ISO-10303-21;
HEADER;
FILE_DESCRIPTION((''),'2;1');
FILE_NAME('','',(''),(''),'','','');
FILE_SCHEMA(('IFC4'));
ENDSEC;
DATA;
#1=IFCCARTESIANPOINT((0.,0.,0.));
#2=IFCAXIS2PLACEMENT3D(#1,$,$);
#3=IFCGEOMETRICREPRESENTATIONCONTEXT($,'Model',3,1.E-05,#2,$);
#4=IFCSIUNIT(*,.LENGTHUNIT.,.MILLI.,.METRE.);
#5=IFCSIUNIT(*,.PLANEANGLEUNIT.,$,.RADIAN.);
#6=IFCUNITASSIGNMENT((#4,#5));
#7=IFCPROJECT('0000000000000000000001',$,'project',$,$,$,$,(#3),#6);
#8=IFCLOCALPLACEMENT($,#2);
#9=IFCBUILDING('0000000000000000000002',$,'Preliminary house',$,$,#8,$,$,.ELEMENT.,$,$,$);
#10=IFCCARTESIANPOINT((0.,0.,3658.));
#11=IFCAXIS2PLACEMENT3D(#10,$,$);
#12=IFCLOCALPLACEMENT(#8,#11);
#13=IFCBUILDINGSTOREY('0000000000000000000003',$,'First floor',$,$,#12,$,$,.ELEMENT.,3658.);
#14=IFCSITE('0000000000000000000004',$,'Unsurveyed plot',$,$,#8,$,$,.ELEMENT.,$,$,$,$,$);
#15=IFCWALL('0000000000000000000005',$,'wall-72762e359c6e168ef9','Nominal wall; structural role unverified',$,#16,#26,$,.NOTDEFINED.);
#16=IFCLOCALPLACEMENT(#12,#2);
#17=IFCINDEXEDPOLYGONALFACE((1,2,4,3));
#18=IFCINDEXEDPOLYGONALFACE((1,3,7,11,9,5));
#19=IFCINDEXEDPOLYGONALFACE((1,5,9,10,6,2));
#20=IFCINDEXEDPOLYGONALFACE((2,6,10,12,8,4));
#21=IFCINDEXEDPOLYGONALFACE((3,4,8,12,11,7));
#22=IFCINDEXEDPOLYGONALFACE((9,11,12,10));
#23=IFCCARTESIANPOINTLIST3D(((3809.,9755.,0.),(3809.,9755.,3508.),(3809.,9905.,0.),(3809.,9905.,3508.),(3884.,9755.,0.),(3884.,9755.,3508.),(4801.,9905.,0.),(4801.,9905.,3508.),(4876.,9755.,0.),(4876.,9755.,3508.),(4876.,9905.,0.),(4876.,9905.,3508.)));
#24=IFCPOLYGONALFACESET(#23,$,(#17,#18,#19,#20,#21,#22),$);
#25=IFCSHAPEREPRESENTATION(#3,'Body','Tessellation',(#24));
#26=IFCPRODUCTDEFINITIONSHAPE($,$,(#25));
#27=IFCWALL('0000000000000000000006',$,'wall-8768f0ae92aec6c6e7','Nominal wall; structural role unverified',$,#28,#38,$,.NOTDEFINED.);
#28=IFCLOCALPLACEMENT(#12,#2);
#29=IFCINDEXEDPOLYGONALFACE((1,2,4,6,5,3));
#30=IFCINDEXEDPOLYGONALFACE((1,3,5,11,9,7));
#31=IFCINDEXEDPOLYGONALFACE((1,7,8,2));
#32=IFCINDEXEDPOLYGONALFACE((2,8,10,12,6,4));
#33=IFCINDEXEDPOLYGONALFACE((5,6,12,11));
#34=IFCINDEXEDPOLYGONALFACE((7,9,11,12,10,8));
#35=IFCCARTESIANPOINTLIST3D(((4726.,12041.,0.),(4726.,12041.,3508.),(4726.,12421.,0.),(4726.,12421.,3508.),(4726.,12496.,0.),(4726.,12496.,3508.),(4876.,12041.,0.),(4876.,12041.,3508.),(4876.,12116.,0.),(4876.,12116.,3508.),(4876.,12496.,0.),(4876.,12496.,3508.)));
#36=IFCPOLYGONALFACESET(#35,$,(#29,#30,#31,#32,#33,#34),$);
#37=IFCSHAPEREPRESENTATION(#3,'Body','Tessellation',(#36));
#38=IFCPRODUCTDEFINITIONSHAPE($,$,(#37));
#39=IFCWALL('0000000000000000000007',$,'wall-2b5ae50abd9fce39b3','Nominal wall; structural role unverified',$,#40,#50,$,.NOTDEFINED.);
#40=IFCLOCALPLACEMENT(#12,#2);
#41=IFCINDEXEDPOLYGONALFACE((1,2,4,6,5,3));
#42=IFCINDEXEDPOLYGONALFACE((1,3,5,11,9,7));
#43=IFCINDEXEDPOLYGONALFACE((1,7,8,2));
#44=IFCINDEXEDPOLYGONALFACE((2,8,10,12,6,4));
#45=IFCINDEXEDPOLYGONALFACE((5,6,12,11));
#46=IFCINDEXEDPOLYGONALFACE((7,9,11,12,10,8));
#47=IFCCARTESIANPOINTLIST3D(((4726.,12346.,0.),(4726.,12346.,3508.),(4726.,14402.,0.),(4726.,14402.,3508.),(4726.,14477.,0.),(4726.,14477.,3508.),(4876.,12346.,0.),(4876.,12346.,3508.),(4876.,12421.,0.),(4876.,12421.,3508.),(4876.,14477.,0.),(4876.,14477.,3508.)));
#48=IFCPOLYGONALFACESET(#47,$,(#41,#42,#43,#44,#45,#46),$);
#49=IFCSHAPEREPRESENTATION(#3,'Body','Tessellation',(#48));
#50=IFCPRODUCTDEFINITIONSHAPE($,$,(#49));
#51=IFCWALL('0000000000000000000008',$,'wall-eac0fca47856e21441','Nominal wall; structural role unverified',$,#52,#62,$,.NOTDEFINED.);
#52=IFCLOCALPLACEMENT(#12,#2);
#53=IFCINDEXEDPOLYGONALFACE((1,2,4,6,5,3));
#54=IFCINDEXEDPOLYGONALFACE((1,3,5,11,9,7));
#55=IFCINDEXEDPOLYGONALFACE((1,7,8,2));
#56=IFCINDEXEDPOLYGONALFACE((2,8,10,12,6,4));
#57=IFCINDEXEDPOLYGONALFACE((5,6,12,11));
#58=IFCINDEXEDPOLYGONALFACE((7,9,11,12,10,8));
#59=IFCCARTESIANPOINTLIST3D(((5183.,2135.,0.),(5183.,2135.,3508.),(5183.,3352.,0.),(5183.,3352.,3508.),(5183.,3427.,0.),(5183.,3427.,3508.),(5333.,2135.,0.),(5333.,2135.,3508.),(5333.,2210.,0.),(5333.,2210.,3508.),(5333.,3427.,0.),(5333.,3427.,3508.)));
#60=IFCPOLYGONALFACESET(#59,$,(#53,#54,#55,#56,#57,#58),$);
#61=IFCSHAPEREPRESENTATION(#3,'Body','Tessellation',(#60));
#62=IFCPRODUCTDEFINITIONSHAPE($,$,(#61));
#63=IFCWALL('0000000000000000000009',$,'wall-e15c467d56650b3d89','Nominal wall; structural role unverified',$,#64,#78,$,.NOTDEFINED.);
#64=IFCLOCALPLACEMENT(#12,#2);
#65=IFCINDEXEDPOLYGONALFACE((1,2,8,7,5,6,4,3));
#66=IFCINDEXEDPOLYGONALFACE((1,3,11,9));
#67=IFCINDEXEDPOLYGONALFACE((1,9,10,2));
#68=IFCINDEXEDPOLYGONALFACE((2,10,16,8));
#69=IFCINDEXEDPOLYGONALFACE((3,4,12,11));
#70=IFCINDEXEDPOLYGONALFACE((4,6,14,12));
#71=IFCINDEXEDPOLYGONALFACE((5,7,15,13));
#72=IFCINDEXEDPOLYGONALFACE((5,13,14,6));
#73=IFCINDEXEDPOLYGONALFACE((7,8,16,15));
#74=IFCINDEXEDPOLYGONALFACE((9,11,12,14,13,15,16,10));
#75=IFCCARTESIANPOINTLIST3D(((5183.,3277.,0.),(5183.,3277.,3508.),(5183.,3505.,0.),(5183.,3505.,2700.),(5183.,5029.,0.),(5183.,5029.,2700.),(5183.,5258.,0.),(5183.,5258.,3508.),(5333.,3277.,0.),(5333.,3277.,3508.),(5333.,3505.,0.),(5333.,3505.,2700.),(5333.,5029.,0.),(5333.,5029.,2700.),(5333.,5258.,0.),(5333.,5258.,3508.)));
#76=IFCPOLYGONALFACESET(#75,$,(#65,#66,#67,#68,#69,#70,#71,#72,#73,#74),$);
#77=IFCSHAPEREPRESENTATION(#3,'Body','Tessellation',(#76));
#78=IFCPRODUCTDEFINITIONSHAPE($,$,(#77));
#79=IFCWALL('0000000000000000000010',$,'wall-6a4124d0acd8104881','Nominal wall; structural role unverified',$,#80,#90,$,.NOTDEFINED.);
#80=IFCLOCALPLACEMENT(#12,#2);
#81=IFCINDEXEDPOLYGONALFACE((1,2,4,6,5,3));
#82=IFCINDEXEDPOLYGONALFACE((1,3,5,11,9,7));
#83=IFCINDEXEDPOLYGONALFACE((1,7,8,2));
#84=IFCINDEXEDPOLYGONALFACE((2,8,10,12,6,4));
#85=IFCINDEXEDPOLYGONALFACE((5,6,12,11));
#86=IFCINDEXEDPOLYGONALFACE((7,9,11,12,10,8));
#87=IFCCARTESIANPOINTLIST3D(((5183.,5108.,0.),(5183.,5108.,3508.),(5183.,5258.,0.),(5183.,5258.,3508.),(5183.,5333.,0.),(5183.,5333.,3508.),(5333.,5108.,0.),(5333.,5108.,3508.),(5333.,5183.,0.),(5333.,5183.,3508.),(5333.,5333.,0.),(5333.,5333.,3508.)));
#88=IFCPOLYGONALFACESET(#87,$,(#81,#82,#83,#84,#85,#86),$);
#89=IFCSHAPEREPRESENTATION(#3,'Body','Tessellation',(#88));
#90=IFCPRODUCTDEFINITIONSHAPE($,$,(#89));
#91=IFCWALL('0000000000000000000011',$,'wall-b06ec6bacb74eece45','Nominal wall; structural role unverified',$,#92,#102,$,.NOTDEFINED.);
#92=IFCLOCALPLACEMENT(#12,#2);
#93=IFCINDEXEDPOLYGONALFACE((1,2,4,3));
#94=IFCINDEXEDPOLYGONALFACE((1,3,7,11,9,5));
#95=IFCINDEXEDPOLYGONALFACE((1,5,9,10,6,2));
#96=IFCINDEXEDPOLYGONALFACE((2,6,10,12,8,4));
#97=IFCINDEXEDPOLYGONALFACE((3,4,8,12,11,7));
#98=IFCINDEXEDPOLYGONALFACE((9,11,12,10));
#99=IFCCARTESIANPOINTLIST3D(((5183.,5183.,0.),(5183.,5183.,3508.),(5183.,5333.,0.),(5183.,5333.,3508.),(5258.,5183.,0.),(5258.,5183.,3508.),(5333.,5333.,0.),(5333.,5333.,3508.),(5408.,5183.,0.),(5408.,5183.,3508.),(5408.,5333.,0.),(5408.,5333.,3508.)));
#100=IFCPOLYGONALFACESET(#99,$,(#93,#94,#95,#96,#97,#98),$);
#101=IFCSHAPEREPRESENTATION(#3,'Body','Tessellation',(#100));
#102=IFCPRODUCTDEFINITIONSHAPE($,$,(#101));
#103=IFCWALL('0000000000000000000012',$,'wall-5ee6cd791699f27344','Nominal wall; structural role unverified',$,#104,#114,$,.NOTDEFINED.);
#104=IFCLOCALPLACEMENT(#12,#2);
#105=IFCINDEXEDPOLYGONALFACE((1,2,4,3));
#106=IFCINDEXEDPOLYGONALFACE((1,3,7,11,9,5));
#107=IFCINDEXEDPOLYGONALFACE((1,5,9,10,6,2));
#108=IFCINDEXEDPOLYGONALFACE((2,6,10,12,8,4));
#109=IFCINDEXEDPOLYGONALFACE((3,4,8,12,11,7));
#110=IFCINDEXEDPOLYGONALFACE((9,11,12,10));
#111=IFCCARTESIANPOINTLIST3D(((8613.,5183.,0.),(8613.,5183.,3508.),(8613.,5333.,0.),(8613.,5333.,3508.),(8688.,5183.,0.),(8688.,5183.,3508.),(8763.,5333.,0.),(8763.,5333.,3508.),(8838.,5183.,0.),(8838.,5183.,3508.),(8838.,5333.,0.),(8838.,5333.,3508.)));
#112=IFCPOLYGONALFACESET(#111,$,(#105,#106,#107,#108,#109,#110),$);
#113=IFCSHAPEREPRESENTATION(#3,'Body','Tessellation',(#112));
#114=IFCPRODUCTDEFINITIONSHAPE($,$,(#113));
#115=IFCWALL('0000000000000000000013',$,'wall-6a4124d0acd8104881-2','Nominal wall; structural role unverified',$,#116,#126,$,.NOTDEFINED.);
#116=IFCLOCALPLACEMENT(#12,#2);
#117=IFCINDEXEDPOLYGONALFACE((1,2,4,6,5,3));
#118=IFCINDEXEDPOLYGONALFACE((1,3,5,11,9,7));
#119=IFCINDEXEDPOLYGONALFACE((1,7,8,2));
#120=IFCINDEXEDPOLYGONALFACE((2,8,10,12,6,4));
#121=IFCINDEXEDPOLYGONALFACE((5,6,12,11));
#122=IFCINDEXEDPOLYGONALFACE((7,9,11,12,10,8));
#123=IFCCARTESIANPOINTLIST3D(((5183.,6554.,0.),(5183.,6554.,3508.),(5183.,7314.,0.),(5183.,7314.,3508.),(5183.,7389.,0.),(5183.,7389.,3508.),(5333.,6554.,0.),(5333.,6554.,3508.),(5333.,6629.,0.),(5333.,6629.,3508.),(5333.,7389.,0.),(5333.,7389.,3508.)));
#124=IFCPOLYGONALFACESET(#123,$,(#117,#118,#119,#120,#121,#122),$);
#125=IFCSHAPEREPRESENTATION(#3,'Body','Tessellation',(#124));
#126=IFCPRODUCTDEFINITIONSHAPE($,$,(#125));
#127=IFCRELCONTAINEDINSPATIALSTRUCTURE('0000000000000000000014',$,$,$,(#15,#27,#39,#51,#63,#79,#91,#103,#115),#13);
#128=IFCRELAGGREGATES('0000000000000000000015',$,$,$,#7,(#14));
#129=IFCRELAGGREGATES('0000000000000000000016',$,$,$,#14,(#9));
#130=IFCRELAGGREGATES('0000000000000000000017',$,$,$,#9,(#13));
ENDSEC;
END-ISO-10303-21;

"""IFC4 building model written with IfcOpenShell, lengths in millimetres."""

from ifc_helpers import new_model, si_unit, frame, origin, place, context, project, spatial, polyline, outline, extrude, element, save


model = new_model("IFC4")

# Units and contexts
model_context = context("Model", 3, precision=1e-05, world=origin())
ifc_project = project(units=[si_unit("LENGTHUNIT", "METRE", prefix="MILLI"), si_unit("PLANEANGLEUNIT", "RADIAN")], contexts=[model_context])

# Site, building, storey
placement_1 = place(None, origin())
site = spatial("IfcSite", under=ifc_project, at=placement_1, Name="Unsurveyed plot", CompositionType="ELEMENT")
building = spatial("IfcBuilding", under=site, at=placement_1, Name="Preliminary house", CompositionType="ELEMENT")
placement_2 = place(placement_1, frame((0.0, 0.0, 3658.0)))
storey = spatial("IfcBuildingStorey", under=building, at=placement_2, Name="First floor", CompositionType="ELEMENT", Elevation=3658.0)

# Wall
element("IfcWall", 1, at=placement_2, inside=storey, Name="wall-72762e359c6e168ef9", Description="Nominal wall; structural role unverified", PredefinedType="NOTDEFINED", context=model_context, shape_type="SweptSolid", body=[
    extrude(outline(polyline([(4801.0, 9905.0), (4876.0, 9905.0), (4876.0, 9755.0), (3884.0, 9755.0), (3809.0, 9755.0), (3809.0, 9905.0), (4801.0, 9905.0)])), origin(), (0.0, 0.0, 1.0), 3508.0),
])

# Walls
element("IfcWall", 2, at=placement_2, inside=storey, Name="wall-8768f0ae92aec6c6e7", Description="Nominal wall; structural role unverified", PredefinedType="NOTDEFINED", context=model_context, shape_type="SweptSolid", body=[
    extrude(outline(polyline([(4726.0, 12421.0), (4726.0, 12496.0), (4876.0, 12496.0), (4876.0, 12116.0), (4876.0, 12041.0), (4726.0, 12041.0), (4726.0, 12421.0)])), origin(), (0.0, 0.0, 1.0), 3508.0),
])
element("IfcWall", 3, at=placement_2, inside=storey, Name="wall-2b5ae50abd9fce39b3", Description="Nominal wall; structural role unverified", PredefinedType="NOTDEFINED", context=model_context, shape_type="SweptSolid", body=[
    extrude(outline(polyline([(4726.0, 14402.0), (4726.0, 14477.0), (4876.0, 14477.0), (4876.0, 12421.0), (4876.0, 12346.0), (4726.0, 12346.0), (4726.0, 14402.0)])), origin(), (0.0, 0.0, 1.0), 3508.0),
])

# Wall
element("IfcWall", 4, at=placement_2, inside=storey, Name="wall-eac0fca47856e21441", Description="Nominal wall; structural role unverified", PredefinedType="NOTDEFINED", context=model_context, shape_type="SweptSolid", body=[
    extrude(outline(polyline([(5183.0, 3352.0), (5183.0, 3427.0), (5333.0, 3427.0), (5333.0, 2210.0), (5333.0, 2135.0), (5183.0, 2135.0), (5183.0, 3352.0)])), origin(), (0.0, 0.0, 1.0), 3508.0),
])

# Wall, opening
wall_1 = element("IfcWall", 5, at=placement_2, inside=storey, Name="wall-e15c467d56650b3d89", Description="Nominal wall; structural role unverified", PredefinedType="NOTDEFINED", context=model_context, shape_type="SweptSolid", body=[
    extrude(outline(polyline([(5183.0, 5183.0), (5183.0, 5258.0), (5333.0, 5258.0), (5333.0, 3352.0), (5333.0, 3277.0), (5183.0, 3277.0), (5183.0, 5183.0)])), origin(), (0.0, 0.0, 1.0), 3508.0),
])
element("IfcOpeningElement", 6, at=placement_2, cuts=wall_1, PredefinedType="OPENING", context=model_context, shape_type="SweptSolid", body=[
    extrude(outline(polyline([(5708.0, 3505.0), (5708.0, 5029.0), (4808.0, 5029.0), (4808.0, 3505.0), (5708.0, 3505.0)])), origin(), (0.0, 0.0, 1.0), 2700.0),
])

# Wall
element("IfcWall", 7, at=placement_2, inside=storey, Name="wall-6a4124d0acd8104881", Description="Nominal wall; structural role unverified", PredefinedType="NOTDEFINED", context=model_context, shape_type="SweptSolid", body=[
    extrude(outline(polyline([(5183.0, 5258.0), (5183.0, 5333.0), (5333.0, 5333.0), (5333.0, 5183.0), (5333.0, 5108.0), (5183.0, 5108.0), (5183.0, 5258.0)])), origin(), (0.0, 0.0, 1.0), 3508.0),
])

# Wall
element("IfcWall", 8, at=placement_2, inside=storey, Name="wall-b06ec6bacb74eece45", Description="Nominal wall; structural role unverified", PredefinedType="NOTDEFINED", context=model_context, shape_type="SweptSolid", body=[
    extrude(outline(polyline([(5333.0, 5333.0), (5408.0, 5333.0), (5408.0, 5183.0), (5258.0, 5183.0), (5183.0, 5183.0), (5183.0, 5333.0), (5333.0, 5333.0)])), origin(), (0.0, 0.0, 1.0), 3508.0),
])

# Walls
element("IfcWall", 9, at=placement_2, inside=storey, Name="wall-5ee6cd791699f27344", Description="Nominal wall; structural role unverified", PredefinedType="NOTDEFINED", context=model_context, shape_type="SweptSolid", body=[
    extrude(outline(polyline([(8763.0, 5333.0), (8838.0, 5333.0), (8838.0, 5183.0), (8688.0, 5183.0), (8613.0, 5183.0), (8613.0, 5333.0), (8763.0, 5333.0)])), origin(), (0.0, 0.0, 1.0), 3508.0),
])
element("IfcWall", 10, at=placement_2, inside=storey, Name="wall-6a4124d0acd8104881-2", Description="Nominal wall; structural role unverified", PredefinedType="NOTDEFINED", context=model_context, shape_type="SweptSolid", body=[
    extrude(outline(polyline([(5183.0, 7314.0), (5183.0, 7389.0), (5333.0, 7389.0), (5333.0, 6629.0), (5333.0, 6554.0), (5183.0, 6554.0), (5183.0, 7314.0)])), origin(), (0.0, 0.0, 1.0), 3508.0),
])

save(model, "model.ifc")
